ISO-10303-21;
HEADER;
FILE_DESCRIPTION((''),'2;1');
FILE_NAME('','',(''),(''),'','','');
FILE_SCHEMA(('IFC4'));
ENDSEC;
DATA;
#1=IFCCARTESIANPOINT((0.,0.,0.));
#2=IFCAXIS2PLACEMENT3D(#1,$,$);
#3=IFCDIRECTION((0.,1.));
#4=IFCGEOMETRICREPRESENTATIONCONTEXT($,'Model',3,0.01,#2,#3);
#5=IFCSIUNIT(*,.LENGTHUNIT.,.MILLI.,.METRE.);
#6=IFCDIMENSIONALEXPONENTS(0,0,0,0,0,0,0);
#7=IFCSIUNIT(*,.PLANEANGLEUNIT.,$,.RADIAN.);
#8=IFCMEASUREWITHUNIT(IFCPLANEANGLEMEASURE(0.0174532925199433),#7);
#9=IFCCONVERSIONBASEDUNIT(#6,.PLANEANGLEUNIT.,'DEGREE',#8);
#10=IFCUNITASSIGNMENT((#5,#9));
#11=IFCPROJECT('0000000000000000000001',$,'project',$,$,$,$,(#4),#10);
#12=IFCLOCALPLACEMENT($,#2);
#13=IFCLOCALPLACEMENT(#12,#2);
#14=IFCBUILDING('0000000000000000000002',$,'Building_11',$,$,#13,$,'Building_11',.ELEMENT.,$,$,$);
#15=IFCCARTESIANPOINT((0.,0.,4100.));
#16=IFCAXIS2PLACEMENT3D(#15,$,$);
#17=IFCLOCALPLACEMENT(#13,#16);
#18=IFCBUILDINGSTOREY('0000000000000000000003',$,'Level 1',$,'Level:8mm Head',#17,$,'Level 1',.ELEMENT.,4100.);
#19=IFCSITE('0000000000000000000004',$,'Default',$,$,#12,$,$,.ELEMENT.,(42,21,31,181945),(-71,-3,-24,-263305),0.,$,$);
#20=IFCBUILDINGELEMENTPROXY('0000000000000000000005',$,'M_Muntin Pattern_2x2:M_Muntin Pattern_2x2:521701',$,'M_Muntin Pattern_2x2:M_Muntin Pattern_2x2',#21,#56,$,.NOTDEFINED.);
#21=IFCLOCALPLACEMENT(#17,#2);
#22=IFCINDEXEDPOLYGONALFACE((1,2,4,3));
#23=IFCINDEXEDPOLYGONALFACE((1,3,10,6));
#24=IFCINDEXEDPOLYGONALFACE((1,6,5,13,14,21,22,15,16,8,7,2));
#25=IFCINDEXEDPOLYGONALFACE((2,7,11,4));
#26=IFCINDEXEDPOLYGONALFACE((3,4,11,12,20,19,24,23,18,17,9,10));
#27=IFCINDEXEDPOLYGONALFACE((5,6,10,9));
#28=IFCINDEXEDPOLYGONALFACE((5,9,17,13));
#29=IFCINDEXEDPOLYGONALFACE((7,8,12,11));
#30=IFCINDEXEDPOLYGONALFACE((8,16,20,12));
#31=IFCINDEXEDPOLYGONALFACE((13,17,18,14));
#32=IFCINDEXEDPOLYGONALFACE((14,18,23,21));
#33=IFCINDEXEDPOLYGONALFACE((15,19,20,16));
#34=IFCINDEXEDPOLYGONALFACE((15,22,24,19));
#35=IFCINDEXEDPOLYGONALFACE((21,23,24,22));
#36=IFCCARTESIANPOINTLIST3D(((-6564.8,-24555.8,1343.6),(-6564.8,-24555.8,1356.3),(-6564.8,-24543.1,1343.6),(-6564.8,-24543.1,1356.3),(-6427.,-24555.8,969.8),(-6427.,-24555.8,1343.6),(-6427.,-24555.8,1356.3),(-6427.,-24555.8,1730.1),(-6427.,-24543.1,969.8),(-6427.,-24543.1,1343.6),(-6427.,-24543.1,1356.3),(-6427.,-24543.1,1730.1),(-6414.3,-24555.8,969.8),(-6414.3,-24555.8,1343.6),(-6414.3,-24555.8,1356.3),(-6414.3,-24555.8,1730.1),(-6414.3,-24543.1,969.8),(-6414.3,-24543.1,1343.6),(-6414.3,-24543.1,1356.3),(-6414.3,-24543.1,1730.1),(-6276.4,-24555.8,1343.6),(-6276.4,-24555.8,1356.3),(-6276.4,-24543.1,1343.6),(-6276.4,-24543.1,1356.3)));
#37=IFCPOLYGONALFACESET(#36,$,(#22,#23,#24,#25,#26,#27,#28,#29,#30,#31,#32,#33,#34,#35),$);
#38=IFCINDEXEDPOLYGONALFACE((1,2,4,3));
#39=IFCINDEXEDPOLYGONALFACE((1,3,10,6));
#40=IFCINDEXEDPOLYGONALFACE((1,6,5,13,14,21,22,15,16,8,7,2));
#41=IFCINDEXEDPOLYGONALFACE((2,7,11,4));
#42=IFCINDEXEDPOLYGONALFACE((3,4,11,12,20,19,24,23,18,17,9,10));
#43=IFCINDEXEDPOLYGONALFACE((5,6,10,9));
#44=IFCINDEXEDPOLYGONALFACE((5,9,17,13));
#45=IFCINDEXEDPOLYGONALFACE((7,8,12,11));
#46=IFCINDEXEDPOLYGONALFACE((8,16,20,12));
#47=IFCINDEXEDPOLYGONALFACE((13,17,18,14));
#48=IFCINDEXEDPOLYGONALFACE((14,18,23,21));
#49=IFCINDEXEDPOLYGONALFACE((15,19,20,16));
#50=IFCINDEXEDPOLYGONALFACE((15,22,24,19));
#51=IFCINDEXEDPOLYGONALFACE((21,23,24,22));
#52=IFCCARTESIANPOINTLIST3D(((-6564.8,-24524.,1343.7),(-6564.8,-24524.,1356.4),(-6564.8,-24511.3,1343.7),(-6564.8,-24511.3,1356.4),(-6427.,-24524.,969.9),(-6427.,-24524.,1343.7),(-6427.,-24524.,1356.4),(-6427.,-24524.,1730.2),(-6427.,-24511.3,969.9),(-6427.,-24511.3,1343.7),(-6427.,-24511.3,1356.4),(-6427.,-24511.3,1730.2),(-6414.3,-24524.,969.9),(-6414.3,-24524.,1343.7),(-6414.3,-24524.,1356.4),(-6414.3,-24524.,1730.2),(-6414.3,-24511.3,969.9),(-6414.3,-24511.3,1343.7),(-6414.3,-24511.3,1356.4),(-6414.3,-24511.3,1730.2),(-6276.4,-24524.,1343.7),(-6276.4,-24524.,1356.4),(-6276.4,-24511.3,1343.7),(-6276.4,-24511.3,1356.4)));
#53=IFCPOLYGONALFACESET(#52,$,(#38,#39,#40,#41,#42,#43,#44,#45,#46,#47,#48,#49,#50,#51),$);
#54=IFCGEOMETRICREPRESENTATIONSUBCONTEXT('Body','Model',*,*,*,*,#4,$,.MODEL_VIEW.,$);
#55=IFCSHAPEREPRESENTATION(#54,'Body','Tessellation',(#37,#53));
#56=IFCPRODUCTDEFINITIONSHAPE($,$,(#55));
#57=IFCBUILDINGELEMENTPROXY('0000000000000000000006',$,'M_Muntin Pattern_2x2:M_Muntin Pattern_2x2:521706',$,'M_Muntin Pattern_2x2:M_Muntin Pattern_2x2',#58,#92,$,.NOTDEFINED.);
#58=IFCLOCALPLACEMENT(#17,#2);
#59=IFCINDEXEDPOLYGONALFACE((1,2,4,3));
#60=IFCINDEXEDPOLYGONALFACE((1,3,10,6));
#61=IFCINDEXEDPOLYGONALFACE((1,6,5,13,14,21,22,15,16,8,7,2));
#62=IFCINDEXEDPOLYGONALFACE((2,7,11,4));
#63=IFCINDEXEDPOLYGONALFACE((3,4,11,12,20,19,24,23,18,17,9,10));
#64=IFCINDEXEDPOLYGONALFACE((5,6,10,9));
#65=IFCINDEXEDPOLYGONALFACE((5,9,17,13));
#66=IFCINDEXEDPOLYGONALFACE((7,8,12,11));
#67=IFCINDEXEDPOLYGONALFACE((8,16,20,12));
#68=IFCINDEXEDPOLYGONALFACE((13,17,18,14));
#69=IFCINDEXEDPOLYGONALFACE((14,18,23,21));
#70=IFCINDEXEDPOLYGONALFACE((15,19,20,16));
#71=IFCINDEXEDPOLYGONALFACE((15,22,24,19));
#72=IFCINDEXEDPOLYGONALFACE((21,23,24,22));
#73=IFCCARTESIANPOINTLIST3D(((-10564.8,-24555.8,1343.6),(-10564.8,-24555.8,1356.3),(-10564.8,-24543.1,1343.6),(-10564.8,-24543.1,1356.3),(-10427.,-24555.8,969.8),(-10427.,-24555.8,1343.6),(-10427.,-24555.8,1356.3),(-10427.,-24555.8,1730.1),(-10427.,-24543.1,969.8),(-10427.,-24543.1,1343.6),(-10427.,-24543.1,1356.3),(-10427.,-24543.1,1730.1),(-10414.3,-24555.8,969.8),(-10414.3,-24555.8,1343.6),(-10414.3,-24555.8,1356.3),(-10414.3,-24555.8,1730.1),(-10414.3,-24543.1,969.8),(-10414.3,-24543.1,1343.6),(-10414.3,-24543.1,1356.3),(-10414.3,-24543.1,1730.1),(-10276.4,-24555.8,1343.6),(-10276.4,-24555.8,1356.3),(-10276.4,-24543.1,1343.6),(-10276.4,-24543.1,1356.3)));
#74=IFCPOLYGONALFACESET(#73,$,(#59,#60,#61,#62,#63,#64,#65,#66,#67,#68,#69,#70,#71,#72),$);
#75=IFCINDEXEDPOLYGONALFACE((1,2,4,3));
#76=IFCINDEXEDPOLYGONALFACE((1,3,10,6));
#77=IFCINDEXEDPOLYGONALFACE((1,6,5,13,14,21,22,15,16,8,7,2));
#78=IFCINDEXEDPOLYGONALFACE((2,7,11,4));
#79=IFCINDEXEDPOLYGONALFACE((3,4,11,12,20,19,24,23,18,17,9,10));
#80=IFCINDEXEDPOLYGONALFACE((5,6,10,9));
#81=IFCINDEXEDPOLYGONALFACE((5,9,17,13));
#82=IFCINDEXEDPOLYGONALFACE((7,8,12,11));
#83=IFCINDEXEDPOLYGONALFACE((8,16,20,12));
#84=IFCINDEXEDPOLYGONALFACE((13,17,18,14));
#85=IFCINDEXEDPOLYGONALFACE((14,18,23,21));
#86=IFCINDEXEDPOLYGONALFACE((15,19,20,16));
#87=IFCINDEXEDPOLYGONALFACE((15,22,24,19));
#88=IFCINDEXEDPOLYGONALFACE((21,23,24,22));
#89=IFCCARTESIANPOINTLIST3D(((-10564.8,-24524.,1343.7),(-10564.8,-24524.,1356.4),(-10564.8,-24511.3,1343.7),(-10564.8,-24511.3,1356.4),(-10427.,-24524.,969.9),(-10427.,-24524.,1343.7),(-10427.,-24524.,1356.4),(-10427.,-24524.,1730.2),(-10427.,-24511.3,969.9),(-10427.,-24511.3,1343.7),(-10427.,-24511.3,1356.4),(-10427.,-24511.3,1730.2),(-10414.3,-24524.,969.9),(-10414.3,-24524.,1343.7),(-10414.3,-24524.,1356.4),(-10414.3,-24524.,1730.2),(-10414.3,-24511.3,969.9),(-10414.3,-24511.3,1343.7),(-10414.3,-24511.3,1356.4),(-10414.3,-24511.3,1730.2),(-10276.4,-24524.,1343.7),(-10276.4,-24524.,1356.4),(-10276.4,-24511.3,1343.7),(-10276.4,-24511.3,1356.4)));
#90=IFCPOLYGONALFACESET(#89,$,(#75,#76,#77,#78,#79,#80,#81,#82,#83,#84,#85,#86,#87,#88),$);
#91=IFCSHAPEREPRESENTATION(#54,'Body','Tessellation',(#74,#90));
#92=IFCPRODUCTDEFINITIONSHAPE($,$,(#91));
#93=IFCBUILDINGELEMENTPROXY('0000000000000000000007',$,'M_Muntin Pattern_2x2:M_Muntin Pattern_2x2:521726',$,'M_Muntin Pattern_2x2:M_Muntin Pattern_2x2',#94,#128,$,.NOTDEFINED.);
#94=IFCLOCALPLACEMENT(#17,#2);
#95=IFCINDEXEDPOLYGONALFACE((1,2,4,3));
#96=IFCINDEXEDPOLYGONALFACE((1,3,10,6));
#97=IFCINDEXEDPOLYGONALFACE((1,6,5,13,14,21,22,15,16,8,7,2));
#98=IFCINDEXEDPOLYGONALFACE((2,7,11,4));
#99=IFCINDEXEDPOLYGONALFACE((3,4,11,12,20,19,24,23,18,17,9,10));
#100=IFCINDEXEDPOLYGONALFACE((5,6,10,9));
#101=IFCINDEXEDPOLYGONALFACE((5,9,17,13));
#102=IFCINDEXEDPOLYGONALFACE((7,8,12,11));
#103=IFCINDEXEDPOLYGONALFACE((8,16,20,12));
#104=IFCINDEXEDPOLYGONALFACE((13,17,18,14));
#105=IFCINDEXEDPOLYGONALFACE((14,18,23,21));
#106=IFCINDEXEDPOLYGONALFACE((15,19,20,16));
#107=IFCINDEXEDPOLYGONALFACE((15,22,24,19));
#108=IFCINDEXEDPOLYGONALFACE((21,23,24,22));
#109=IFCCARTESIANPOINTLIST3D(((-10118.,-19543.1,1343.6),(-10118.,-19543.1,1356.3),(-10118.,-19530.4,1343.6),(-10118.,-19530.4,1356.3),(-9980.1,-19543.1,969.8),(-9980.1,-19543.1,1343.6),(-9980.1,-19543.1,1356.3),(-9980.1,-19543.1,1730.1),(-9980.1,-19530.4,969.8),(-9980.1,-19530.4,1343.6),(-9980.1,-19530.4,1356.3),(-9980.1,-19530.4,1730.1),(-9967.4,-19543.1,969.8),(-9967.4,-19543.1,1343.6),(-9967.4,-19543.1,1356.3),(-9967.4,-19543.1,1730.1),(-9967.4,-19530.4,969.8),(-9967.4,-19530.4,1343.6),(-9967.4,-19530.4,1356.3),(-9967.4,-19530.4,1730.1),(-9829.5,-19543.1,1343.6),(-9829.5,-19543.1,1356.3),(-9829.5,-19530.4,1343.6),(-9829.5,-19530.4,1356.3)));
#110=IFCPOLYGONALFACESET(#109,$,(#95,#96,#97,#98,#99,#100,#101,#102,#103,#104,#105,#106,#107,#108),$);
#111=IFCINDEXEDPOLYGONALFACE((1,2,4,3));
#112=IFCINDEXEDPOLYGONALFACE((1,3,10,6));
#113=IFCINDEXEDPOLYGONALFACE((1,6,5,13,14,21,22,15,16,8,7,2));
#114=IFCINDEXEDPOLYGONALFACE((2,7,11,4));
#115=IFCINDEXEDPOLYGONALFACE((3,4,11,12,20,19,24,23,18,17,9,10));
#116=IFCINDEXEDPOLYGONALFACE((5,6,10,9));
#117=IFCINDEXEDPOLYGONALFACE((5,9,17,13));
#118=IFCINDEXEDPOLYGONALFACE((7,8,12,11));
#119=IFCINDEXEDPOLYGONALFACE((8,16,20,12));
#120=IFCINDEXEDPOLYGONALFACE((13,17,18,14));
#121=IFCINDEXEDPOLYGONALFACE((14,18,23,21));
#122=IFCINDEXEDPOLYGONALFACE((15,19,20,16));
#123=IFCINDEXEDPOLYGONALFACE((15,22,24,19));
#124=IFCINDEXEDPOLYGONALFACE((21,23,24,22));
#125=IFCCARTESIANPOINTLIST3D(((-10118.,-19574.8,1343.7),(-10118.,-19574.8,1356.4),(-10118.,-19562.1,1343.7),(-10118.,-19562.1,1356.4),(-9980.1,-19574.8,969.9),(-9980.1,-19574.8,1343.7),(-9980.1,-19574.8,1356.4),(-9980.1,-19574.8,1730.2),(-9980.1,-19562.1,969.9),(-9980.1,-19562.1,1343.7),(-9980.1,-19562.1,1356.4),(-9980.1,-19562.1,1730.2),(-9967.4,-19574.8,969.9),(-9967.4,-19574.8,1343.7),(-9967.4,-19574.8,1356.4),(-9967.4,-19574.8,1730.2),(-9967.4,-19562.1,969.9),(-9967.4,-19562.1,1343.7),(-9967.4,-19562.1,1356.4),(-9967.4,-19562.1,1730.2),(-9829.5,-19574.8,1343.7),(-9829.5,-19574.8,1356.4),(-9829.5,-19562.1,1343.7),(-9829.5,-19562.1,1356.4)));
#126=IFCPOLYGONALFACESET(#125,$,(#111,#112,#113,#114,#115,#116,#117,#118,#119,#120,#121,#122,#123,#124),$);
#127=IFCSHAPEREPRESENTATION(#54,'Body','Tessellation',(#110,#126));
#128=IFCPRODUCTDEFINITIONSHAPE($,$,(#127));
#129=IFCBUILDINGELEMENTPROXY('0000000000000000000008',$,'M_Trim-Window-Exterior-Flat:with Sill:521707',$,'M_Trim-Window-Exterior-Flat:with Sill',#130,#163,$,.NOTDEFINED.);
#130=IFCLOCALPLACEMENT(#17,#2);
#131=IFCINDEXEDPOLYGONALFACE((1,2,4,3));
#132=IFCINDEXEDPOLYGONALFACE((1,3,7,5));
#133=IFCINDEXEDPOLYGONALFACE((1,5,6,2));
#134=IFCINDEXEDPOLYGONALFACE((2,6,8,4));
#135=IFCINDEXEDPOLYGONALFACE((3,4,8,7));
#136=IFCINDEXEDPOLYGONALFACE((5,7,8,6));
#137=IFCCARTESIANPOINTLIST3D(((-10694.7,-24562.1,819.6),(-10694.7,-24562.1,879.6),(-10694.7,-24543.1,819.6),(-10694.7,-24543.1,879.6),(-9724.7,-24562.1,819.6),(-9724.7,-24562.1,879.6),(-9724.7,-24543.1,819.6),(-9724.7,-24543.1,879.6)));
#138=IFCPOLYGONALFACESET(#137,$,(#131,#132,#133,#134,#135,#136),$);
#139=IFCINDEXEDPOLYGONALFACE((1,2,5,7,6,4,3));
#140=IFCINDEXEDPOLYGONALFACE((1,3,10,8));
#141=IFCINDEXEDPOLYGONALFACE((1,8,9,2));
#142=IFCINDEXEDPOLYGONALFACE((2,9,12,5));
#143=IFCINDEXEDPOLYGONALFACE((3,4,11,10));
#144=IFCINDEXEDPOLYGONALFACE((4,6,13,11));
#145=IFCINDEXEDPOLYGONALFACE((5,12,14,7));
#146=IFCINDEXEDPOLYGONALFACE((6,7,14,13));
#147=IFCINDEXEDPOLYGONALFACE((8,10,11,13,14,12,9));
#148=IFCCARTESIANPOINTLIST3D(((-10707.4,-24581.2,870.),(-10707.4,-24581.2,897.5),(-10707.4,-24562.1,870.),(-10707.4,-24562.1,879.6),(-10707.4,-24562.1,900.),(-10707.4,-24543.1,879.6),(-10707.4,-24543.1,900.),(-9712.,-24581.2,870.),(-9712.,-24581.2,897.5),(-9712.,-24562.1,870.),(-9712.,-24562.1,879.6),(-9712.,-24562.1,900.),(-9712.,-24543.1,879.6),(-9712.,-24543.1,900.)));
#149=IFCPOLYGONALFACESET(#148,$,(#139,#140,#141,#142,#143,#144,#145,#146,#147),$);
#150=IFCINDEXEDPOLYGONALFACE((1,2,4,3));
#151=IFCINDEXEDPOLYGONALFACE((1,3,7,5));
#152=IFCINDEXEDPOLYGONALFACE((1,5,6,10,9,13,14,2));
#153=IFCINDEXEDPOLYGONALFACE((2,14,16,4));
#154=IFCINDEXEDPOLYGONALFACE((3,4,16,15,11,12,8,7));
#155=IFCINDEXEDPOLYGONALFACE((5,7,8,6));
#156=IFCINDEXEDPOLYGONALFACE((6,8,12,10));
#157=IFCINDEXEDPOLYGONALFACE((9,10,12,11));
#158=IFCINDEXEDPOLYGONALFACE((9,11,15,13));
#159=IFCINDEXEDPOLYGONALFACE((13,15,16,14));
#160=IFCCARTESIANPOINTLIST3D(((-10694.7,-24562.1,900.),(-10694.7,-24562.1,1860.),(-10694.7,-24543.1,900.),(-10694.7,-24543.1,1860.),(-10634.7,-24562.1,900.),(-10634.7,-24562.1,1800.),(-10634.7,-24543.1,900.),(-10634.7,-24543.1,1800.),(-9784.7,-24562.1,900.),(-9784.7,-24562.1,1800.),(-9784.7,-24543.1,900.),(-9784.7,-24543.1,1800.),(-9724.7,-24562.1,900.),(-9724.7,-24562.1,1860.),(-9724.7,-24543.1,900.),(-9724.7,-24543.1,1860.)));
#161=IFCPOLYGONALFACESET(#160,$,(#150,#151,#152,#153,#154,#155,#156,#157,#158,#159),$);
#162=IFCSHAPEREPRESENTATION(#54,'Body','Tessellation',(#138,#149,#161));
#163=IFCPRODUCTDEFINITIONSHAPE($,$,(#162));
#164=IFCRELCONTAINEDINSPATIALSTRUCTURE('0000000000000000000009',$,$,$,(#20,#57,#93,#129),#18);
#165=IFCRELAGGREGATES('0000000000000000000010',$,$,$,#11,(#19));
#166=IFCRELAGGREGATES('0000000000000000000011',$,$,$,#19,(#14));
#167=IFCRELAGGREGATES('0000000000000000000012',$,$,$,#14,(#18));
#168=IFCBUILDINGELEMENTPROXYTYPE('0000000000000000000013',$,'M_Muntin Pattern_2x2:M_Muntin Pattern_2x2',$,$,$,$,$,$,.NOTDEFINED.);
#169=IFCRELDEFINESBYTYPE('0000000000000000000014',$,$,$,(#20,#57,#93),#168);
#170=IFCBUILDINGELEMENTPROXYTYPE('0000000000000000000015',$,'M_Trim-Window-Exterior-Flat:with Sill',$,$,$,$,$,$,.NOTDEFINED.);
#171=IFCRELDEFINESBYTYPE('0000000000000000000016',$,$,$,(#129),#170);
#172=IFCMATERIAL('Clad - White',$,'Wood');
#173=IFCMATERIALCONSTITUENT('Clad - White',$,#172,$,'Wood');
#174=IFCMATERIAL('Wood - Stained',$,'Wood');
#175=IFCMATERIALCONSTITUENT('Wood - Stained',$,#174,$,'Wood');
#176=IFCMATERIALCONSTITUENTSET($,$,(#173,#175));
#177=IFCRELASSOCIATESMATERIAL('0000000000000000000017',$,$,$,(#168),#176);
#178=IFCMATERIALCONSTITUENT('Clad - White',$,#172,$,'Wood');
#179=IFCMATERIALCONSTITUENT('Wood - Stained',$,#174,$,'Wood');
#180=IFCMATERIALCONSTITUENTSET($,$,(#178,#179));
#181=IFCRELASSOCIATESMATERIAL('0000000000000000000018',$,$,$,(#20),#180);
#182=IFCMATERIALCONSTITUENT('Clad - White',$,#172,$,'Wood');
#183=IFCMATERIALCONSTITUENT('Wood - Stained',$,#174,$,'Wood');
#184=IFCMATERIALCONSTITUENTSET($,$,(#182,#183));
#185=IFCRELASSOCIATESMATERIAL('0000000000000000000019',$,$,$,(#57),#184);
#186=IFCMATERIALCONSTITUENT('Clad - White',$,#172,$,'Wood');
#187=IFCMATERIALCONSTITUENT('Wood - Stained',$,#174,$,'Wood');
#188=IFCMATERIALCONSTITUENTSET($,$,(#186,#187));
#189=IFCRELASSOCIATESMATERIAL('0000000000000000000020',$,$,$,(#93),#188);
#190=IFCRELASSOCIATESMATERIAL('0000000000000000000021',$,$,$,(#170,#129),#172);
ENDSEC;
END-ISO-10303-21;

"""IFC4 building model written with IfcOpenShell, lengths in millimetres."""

from ifc_helpers import new_model, entity, si_unit, converted_unit, direction, frame, origin, place, context, subcontext, project, spatial, indexed_curve, outline, extrude, source, transform, mapped, material, constituent, constituent_set, type_object, type_shapes, element, save


model = new_model("IFC4")

# Units and contexts
model_context = context("Model", 3, precision=0.01, world=origin(), true_north=direction((0.0, 1.0)))
body_context = subcontext(model_context, "Body", "Model", "MODEL_VIEW")
ifc_project = project(units=[si_unit("LENGTHUNIT", "METRE", prefix="MILLI"), converted_unit("PLANEANGLEUNIT", "DEGREE", entity("IfcPlaneAngleMeasure", 0.0174532925199433), si_unit("PLANEANGLEUNIT", "RADIAN"), dimensions=[0, 0, 0, 0, 0, 0, 0])], contexts=[model_context])

# Site, building, storey
site_placement = place(None, origin())
site = spatial("IfcSite", under=ifc_project, at=site_placement, Name="Default", CompositionType="ELEMENT", RefLatitude=(42, 21, 31, 181945), RefLongitude=(-71, -3, -24, -263305), RefElevation=0.0)
building_placement = place(site_placement, origin())
building = spatial("IfcBuilding", under=site, at=building_placement, Name="Building_11", LongName="Building_11", CompositionType="ELEMENT")
storey_placement = place(building_placement, frame((0.0, 0.0, 4100.0)))
storey = spatial("IfcBuildingStorey", under=building, at=storey_placement, Name="Level 1", ObjectType="Level:8mm Head", LongName="Level 1", CompositionType="ELEMENT", Elevation=4100.0)

# Building element proxies
ifc_material_1 = material(Name="Clad - White", Category="Wood")
ifc_material_2 = material(Name="Wood - Stained", Category="Wood")
ifc_constituent_1 = constituent(ifc_material_1, Name="Clad - White", Category="Wood")
ifc_constituent_2 = constituent(ifc_material_2, Name="Wood - Stained", Category="Wood")
ifc_constituent_set_1 = constituent_set(constituents=[ifc_constituent_1, ifc_constituent_2])
ifc_constituent_3 = constituent(ifc_material_1, Name="Clad - White", Category="Wood")
ifc_constituent_4 = constituent(ifc_material_2, Name="Wood - Stained", Category="Wood")
ifc_constituent_set_2 = constituent_set(constituents=[ifc_constituent_3, ifc_constituent_4])
building_element_proxy_type_1 = type_object("IfcBuildingElementProxyType", Name="M_Muntin Pattern_2x2:M_Muntin Pattern_2x2", PredefinedType="NOTDEFINED", material=ifc_constituent_set_2)
shared_shape_1 = source(origin(), body_context, "Body", "SweptSolid", [
    extrude(outline(indexed_curve([(6.4, -6.4), (380.1, -6.4), (380.1, 6.3), (6.4, 6.3), (6.4, 144.2), (-6.3, 144.2), (-6.3, 6.3), (-380.2, 6.3), (-380.2, -6.4), (-6.3, -6.4), (-6.3, -144.2), (6.4, -144.2), (6.4, -6.4)], self_intersect=False)), frame((0.0, -22.2, 380.1), z_axis=(0.0, 1.0, 0.0), x_axis=(0.0, 0.0, 1.0)), (0.0, 0.0, 1.0), 12.7),
    extrude(outline(indexed_curve([(6.4, -6.4), (380.2, -6.4), (380.2, 6.3), (6.4, 6.3), (6.4, 144.2), (-6.3, 144.2), (-6.3, 6.3), (-380.2, 6.3), (-380.2, -6.4), (-6.3, -6.4), (-6.3, -144.2), (6.4, -144.2), (6.4, -6.4)], self_intersect=False)), frame((0.0, 9.5, 380.2), z_axis=(0.0, 1.0, 0.0), x_axis=(0.0, 0.0, 1.0)), (0.0, 0.0, 1.0), 12.7),
])
type_shapes(building_element_proxy_type_1, [shared_shape_1])
proxy_1_placement = place(storey_placement, frame((-6420.6, -24533.6, 969.9)))
element("IfcBuildingElementProxy", 1, at=proxy_1_placement, inside=storey, type_object=building_element_proxy_type_1, material=ifc_constituent_set_1, Name="M_Muntin Pattern_2x2:M_Muntin Pattern_2x2:521701", ObjectType="M_Muntin Pattern_2x2:M_Muntin Pattern_2x2", PredefinedType="NOTDEFINED", context=body_context, shape_type="MappedRepresentation", body=[
    mapped(shared_shape_1, transform((0.0, 0.0, 0.0), scale=1.0)),
])
ifc_constituent_5 = constituent(ifc_material_1, Name="Clad - White", Category="Wood")
ifc_constituent_6 = constituent(ifc_material_2, Name="Wood - Stained", Category="Wood")
ifc_constituent_set_3 = constituent_set(constituents=[ifc_constituent_5, ifc_constituent_6])
proxy_2_placement = place(storey_placement, frame((-10420.6, -24533.6, 969.9)))
element("IfcBuildingElementProxy", 2, at=proxy_2_placement, inside=storey, type_object=building_element_proxy_type_1, material=ifc_constituent_set_3, Name="M_Muntin Pattern_2x2:M_Muntin Pattern_2x2:521706", ObjectType="M_Muntin Pattern_2x2:M_Muntin Pattern_2x2", PredefinedType="NOTDEFINED", context=body_context, shape_type="MappedRepresentation", body=[
    mapped(shared_shape_1, transform((0.0, 0.0, 0.0), scale=1.0)),
])
ifc_constituent_7 = constituent(ifc_material_1, Name="Clad - White", Category="Wood")
ifc_constituent_8 = constituent(ifc_material_2, Name="Wood - Stained", Category="Wood")
ifc_constituent_set_4 = constituent_set(constituents=[ifc_constituent_7, ifc_constituent_8])
proxy_3_placement = place(storey_placement, frame((-9973.8, -19552.6, 969.9), z_axis=(0.0, 0.0, 1.0), x_axis=(-1.0, 0.0, 0.0)))
element("IfcBuildingElementProxy", 3, at=proxy_3_placement, inside=storey, type_object=building_element_proxy_type_1, material=ifc_constituent_set_4, Name="M_Muntin Pattern_2x2:M_Muntin Pattern_2x2:521726", ObjectType="M_Muntin Pattern_2x2:M_Muntin Pattern_2x2", PredefinedType="NOTDEFINED", context=body_context, shape_type="MappedRepresentation", body=[
    mapped(shared_shape_1, transform((0.0, 0.0, 0.0), scale=1.0)),
])
building_element_proxy_type_2 = type_object("IfcBuildingElementProxyType", Name="M_Trim-Window-Exterior-Flat:with Sill", PredefinedType="NOTDEFINED", material=ifc_material_1)
shared_shape_2 = source(origin(), body_context, "Body", "SweptSolid", [
    extrude(outline(indexed_curve([(-485.0, -30.0), (485.0, -30.0), (485.0, 30.0), (-485.0, 30.0), (-485.0, -30.0)], self_intersect=False)), frame((0.0, -950.4, 0.0), z_axis=(0.0, 0.0, 1.0), x_axis=(-1.0, 0.0, 0.0)), (0.0, 0.0, 1.0), 19.1),
    extrude(outline(indexed_curve([(-19.0, -15.2), (0.0, -15.2), (0.0, -5.7), (19.0, -5.7), (19.0, 14.8), (0.0, 14.8), (-19.0, 12.3), (-19.0, -15.2)], self_intersect=False)), frame((-497.7, -914.8, 19.0), z_axis=(1.0, 0.0, 0.0), x_axis=(0.0, 0.0, -1.0)), (0.0, 0.0, 1.0), 995.4),
    extrude(outline(indexed_curve([(-495.0, -485.0), (465.0, -485.0), (465.0, -425.0), (-435.0, -425.0), (-435.0, 425.0), (465.0, 425.0), (465.0, 485.0), (-495.0, 485.0), (-495.0, -485.0)], self_intersect=False)), frame((0.0, -435.0, 0.0), z_axis=(0.0, 0.0, 1.0), x_axis=(0.0, -1.0, 0.0)), (0.0, 0.0, 1.0), 19.1),
])
type_shapes(building_element_proxy_type_2, [shared_shape_2])
for number, where, z_axis, x_axis, name in (
    (4, (-10209.7, -24543.1, 1800.0), (0.0, -1.0, 0.0), (1.0, 0.0, 0.0), "M_Trim-Window-Exterior-Flat:with Sill:521707"),
):
    element("IfcBuildingElementProxy", number, at=place(storey_placement, frame(where, z_axis=z_axis, x_axis=x_axis)), inside=storey, type_object=building_element_proxy_type_2, material=ifc_material_1, Name=name, ObjectType="M_Trim-Window-Exterior-Flat:with Sill", PredefinedType="NOTDEFINED", context=body_context, shape_type="MappedRepresentation", body=[
        mapped(shared_shape_2, transform((0.0, 0.0, 0.0), scale=1.0)),
    ])

save(model, "model.ifc")
